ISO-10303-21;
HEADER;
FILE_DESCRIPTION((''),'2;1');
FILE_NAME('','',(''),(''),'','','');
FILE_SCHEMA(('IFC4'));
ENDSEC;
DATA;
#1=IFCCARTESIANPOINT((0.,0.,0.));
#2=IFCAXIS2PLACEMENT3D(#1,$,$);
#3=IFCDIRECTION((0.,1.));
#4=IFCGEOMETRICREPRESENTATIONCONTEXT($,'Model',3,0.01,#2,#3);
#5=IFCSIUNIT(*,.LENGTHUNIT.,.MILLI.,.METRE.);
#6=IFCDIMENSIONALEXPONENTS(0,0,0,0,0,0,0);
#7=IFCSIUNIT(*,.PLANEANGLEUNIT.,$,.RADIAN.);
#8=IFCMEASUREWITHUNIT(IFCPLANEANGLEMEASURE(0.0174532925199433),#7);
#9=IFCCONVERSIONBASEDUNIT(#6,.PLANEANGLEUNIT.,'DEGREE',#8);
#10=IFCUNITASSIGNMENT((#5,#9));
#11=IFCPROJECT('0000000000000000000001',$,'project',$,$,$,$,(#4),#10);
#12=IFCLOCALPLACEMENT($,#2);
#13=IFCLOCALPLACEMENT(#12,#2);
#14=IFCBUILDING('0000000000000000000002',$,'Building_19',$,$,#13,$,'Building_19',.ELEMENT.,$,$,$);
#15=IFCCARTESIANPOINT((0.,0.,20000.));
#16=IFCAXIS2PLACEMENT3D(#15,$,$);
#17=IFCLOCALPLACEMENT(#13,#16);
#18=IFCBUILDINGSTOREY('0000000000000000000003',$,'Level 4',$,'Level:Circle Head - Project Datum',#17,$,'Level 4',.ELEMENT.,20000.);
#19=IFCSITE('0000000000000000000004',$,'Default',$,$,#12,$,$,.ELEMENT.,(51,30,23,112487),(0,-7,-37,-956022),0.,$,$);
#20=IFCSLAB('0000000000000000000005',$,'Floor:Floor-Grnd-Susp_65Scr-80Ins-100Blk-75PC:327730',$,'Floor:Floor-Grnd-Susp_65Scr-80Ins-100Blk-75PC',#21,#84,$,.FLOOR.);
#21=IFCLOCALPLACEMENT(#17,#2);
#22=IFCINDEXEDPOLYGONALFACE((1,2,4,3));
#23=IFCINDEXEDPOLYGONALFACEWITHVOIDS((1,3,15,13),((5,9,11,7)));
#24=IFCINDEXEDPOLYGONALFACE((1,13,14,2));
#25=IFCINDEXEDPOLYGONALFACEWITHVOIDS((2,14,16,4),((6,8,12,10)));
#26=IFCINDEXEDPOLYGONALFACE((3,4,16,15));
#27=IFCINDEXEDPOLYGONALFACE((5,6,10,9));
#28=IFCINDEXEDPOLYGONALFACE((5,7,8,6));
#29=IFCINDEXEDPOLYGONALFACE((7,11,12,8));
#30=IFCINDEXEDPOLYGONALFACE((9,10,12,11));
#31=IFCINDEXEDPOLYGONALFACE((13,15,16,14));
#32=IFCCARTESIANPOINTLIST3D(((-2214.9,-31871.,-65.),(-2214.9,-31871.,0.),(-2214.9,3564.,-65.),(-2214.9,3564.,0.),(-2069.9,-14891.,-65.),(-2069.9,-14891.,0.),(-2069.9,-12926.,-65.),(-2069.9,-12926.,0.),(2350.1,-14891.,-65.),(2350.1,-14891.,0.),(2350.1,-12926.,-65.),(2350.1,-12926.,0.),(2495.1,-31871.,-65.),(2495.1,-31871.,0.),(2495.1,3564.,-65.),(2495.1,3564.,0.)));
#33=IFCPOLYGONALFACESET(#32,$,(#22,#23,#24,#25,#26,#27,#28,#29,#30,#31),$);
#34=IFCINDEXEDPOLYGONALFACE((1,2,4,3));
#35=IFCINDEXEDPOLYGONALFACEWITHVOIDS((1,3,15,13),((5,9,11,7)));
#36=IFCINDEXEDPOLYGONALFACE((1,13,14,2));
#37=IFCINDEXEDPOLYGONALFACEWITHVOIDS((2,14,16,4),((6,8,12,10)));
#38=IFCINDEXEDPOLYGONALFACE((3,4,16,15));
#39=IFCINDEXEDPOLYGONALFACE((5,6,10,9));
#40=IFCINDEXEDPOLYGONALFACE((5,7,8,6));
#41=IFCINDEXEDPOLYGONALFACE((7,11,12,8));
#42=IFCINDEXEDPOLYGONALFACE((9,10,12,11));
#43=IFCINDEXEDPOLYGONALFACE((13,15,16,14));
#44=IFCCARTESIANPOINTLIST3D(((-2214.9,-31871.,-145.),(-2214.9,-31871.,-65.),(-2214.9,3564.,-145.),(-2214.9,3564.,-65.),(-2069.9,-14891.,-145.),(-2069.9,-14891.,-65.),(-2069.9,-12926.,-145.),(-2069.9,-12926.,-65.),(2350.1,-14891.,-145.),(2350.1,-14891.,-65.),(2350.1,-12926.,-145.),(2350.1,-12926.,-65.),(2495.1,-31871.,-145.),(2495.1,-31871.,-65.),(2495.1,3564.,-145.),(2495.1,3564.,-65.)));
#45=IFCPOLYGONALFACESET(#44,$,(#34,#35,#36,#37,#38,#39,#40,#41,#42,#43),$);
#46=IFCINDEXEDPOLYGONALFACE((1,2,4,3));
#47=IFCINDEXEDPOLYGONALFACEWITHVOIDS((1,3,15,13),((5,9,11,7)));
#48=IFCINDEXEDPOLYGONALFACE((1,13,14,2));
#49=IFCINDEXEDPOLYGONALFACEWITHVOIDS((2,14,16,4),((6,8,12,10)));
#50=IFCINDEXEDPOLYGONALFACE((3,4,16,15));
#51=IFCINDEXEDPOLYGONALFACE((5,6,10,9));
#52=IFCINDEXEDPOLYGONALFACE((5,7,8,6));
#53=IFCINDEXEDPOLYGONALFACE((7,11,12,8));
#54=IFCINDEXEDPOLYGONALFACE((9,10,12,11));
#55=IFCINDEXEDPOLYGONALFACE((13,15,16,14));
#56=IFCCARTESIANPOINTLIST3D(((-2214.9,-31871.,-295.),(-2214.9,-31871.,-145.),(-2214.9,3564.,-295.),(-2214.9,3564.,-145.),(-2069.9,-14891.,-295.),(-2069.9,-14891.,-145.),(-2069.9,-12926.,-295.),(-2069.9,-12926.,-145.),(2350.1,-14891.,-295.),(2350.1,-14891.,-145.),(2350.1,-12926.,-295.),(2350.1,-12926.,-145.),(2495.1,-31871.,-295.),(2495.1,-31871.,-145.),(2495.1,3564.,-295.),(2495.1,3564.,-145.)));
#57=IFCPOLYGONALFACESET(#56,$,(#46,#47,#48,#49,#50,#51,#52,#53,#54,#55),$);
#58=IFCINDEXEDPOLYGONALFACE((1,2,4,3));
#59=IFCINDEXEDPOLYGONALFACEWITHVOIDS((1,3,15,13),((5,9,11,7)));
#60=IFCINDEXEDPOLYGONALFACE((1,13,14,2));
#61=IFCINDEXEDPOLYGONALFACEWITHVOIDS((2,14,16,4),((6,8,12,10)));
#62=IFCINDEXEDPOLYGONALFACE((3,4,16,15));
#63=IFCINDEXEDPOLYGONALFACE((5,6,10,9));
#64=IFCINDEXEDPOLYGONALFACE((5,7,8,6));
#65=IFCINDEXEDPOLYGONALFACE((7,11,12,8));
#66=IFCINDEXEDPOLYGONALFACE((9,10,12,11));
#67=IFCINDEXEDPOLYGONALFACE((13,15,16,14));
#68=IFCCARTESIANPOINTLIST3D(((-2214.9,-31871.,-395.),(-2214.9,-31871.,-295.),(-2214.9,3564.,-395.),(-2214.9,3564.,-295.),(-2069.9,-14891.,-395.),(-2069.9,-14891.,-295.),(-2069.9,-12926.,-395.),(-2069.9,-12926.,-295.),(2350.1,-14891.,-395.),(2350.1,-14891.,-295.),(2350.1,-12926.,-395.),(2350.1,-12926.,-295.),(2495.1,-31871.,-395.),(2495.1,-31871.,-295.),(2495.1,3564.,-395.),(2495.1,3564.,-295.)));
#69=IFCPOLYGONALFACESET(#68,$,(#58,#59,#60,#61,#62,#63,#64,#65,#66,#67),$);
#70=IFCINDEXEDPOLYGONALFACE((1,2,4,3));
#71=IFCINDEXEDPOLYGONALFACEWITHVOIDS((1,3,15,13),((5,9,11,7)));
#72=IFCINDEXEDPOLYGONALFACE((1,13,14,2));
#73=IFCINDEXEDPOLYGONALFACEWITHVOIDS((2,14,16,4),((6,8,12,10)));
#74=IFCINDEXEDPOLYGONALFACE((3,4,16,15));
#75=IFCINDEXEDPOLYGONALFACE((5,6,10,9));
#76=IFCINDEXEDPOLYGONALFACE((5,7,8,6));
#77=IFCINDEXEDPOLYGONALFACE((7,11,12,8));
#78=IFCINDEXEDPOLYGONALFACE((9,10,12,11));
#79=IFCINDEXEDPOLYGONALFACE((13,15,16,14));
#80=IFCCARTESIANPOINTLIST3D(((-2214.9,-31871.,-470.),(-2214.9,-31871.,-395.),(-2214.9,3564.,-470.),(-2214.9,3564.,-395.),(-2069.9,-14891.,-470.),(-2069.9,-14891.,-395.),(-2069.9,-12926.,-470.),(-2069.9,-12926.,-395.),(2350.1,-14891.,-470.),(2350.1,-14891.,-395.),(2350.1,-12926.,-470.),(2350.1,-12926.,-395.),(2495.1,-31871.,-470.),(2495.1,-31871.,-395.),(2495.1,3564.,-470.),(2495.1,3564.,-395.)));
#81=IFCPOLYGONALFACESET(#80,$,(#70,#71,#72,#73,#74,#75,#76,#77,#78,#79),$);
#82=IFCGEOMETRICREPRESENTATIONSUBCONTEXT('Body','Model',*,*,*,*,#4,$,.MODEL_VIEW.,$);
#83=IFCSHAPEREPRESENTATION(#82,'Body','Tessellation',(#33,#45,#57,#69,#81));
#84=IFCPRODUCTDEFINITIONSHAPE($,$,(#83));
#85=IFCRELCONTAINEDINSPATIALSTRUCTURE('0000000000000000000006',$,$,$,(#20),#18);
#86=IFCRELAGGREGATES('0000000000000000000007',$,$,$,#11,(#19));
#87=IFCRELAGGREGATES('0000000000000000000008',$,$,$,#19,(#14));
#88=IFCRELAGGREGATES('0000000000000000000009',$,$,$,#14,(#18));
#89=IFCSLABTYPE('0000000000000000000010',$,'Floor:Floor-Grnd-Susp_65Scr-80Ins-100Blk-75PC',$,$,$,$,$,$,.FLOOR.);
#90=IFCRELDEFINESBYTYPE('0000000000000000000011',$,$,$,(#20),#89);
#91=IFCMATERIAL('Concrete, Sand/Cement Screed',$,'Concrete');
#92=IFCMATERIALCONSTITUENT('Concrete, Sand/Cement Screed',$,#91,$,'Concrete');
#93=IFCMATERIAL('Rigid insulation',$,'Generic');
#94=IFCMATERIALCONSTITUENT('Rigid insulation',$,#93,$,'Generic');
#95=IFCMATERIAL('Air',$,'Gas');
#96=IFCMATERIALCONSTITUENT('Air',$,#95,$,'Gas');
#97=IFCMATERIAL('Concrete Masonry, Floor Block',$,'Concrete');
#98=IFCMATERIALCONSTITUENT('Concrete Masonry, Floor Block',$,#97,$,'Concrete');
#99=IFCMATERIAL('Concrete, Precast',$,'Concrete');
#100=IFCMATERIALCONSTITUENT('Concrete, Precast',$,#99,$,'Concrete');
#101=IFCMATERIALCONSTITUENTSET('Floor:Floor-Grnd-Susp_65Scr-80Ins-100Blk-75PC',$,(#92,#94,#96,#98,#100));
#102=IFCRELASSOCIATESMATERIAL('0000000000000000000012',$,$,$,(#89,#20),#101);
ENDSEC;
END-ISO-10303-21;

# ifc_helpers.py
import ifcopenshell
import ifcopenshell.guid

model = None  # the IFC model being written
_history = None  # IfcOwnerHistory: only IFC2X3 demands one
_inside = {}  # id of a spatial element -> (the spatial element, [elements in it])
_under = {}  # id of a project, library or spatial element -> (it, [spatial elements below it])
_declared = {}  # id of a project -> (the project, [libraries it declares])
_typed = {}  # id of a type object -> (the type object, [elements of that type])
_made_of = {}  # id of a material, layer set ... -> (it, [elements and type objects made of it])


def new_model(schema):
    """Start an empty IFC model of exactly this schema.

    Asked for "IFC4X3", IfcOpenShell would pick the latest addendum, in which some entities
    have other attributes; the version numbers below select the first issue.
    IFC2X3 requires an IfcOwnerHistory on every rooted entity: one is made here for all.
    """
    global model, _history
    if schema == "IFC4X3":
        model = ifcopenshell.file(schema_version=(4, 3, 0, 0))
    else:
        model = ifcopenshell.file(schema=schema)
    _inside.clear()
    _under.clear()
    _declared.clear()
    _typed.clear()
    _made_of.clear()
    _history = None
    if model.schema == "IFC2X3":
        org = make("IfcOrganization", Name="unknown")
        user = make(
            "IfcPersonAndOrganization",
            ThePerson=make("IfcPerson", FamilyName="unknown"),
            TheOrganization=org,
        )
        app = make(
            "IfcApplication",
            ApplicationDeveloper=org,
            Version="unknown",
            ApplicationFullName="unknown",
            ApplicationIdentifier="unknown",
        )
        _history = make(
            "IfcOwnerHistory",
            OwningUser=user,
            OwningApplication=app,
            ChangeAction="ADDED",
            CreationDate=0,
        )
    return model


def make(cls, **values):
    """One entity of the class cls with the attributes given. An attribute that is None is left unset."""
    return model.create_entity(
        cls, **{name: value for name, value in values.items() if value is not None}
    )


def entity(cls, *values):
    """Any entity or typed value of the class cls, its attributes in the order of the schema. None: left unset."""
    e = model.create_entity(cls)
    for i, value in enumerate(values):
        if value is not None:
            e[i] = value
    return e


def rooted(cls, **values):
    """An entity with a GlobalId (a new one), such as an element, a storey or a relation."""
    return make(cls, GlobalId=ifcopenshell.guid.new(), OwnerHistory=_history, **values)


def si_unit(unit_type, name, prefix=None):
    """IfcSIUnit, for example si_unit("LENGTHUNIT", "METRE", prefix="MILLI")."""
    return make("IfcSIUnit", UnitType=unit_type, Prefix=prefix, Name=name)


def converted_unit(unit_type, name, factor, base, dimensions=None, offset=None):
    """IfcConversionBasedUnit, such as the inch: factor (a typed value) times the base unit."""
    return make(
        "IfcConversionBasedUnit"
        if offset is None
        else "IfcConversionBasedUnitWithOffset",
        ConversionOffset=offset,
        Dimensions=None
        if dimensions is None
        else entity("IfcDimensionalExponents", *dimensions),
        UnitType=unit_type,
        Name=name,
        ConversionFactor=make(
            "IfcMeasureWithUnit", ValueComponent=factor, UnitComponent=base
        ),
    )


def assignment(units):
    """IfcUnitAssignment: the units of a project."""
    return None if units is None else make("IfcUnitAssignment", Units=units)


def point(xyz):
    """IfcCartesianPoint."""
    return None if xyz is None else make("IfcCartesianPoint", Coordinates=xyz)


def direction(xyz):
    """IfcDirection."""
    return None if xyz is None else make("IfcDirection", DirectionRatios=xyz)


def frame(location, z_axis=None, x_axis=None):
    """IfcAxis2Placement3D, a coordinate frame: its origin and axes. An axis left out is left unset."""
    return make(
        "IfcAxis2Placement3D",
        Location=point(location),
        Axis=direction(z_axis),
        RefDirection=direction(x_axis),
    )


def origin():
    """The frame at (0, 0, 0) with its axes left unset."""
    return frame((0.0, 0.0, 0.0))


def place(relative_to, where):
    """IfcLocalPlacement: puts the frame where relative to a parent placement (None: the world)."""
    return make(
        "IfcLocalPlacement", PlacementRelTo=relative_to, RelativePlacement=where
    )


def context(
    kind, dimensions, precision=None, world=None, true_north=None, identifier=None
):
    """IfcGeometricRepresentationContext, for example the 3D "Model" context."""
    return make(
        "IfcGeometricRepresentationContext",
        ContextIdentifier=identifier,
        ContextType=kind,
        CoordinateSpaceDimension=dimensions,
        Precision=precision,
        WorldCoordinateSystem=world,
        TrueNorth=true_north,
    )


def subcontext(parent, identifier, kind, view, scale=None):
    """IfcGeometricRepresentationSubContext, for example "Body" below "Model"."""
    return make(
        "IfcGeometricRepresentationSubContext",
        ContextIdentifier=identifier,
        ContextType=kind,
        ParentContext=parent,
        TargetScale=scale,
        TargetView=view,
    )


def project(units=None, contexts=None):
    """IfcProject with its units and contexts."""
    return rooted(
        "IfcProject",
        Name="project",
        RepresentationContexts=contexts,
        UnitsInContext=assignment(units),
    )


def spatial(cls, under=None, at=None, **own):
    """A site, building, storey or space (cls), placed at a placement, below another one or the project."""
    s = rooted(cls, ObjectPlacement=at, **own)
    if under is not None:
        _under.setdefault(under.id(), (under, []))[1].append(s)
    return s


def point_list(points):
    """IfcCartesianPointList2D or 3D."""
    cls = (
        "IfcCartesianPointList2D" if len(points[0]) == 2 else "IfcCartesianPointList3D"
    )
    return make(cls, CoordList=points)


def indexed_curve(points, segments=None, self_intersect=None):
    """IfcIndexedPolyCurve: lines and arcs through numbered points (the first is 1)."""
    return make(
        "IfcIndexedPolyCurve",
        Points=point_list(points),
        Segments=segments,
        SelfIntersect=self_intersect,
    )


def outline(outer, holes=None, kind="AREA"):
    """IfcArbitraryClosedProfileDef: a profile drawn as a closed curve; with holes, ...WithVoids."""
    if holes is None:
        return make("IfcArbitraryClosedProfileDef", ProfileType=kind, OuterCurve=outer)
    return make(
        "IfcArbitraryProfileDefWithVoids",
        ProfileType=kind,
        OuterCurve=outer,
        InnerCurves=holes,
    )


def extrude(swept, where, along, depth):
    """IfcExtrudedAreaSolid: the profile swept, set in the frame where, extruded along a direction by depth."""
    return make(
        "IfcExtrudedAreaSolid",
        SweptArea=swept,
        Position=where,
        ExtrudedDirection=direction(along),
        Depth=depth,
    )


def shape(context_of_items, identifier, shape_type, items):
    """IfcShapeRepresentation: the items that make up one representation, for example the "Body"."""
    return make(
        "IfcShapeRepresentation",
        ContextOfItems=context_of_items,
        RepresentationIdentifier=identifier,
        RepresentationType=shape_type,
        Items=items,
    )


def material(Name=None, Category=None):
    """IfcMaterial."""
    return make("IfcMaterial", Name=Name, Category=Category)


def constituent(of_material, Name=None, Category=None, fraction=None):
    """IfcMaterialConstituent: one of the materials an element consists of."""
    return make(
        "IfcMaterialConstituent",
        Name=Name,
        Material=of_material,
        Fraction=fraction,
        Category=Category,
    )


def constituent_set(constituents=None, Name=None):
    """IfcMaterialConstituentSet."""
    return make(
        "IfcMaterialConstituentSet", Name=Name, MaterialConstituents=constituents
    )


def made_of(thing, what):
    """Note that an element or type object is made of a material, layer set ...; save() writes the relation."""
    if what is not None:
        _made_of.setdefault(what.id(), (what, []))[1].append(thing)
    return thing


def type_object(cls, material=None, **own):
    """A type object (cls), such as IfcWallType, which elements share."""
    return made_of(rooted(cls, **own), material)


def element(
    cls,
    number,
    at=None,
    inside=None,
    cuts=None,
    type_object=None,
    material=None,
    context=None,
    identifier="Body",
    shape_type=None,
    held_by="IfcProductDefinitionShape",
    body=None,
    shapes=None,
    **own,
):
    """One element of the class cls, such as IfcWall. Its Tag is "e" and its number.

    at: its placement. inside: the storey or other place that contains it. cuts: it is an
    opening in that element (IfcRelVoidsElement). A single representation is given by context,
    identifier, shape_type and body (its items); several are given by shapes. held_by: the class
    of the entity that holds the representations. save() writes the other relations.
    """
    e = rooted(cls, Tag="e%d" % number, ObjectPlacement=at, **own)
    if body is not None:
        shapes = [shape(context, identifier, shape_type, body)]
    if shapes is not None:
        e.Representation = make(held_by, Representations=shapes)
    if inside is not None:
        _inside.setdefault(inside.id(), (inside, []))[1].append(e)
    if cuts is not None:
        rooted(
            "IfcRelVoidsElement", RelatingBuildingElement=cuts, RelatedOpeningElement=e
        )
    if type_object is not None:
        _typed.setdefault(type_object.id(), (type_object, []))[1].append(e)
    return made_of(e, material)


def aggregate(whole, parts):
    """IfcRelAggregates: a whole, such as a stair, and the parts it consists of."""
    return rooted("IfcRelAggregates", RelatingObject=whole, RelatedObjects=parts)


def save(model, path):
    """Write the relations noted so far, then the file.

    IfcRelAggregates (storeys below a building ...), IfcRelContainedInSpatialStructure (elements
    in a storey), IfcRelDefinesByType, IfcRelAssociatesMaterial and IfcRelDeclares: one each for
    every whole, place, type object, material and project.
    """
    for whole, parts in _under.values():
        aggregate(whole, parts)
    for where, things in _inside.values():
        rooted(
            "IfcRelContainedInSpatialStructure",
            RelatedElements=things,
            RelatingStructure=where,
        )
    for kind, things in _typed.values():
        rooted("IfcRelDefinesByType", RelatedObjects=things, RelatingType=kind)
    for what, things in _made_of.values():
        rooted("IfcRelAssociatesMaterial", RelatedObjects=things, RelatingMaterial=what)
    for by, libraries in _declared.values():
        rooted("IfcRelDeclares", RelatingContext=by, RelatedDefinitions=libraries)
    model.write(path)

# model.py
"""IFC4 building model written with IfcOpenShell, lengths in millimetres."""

from ifc_helpers import new_model, entity, si_unit, converted_unit, direction, frame, origin, place, context, subcontext, project, spatial, indexed_curve, outline, extrude, material, constituent, constituent_set, type_object, element, save


model = new_model("IFC4")

# Units and contexts
model_context = context("Model", 3, precision=0.01, world=origin(), true_north=direction((0.0, 1.0)))
body_context = subcontext(model_context, "Body", "Model", "MODEL_VIEW")
ifc_project = project(units=[si_unit("LENGTHUNIT", "METRE", prefix="MILLI"), converted_unit("PLANEANGLEUNIT", "DEGREE", entity("IfcPlaneAngleMeasure", 0.0174532925199433), si_unit("PLANEANGLEUNIT", "RADIAN"), dimensions=[0, 0, 0, 0, 0, 0, 0])], contexts=[model_context])

# Site, building, storey
site_placement = place(None, origin())
site = spatial("IfcSite", under=ifc_project, at=site_placement, Name="Default", CompositionType="ELEMENT", RefLatitude=(51, 30, 23, 112487), RefLongitude=(0, -7, -37, -956022), RefElevation=0.0)
building_placement = place(site_placement, origin())
building = spatial("IfcBuilding", under=site, at=building_placement, Name="Building_19", LongName="Building_19", CompositionType="ELEMENT")
storey_placement = place(building_placement, frame((0.0, 0.0, 20000.0)))
storey = spatial("IfcBuildingStorey", under=building, at=storey_placement, Name="Level 4", ObjectType="Level:Circle Head - Project Datum", LongName="Level 4", CompositionType="ELEMENT", Elevation=20000.0)

# Slab, opening
ifc_material_1 = material(Name="Concrete, Sand/Cement Screed", Category="Concrete")
ifc_constituent_1 = constituent(ifc_material_1, Name="Concrete, Sand/Cement Screed", Category="Concrete")
ifc_material_2 = material(Name="Rigid insulation", Category="Generic")
ifc_constituent_2 = constituent(ifc_material_2, Name="Rigid insulation", Category="Generic")
ifc_material_3 = material(Name="Air", Category="Gas")
ifc_constituent_3 = constituent(ifc_material_3, Name="Air", Category="Gas")
ifc_material_4 = material(Name="Concrete Masonry, Floor Block", Category="Concrete")
ifc_constituent_4 = constituent(ifc_material_4, Name="Concrete Masonry, Floor Block", Category="Concrete")
ifc_material_5 = material(Name="Concrete, Precast", Category="Concrete")
ifc_constituent_5 = constituent(ifc_material_5, Name="Concrete, Precast", Category="Concrete")
ifc_constituent_set = constituent_set(constituents=[ifc_constituent_1, ifc_constituent_2, ifc_constituent_3, ifc_constituent_4, ifc_constituent_5], Name="Floor:Floor-Grnd-Susp_65Scr-80Ins-100Blk-75PC")
slab_type = type_object("IfcSlabType", Name="Floor:Floor-Grnd-Susp_65Scr-80Ins-100Blk-75PC", PredefinedType="FLOOR", material=ifc_constituent_set)
slab_placement = place(storey_placement, origin())
slab = element("IfcSlab", 1, at=slab_placement, inside=storey, type_object=slab_type, material=ifc_constituent_set, Name="Floor:Floor-Grnd-Susp_65Scr-80Ins-100Blk-75PC:327730", ObjectType="Floor:Floor-Grnd-Susp_65Scr-80Ins-100Blk-75PC", PredefinedType="FLOOR", context=body_context, shape_type="SweptSolid", body=[
    extrude(outline(indexed_curve([(-2355.0, -17717.5), (2355.0, -17717.5), (2355.0, 17717.5), (-2355.0, 17717.5), (-2355.0, -17717.5)], self_intersect=False), holes=[indexed_curve([(-2210.0, 737.5), (2210.0, 737.5), (2210.0, -1227.5), (-2210.0, -1227.5), (-2210.0, 737.5)], self_intersect=False)]), frame((140.1, -14153.5, -65.0), z_axis=(0.0, 0.0, 1.0), x_axis=(-1.0, 0.0, 0.0)), (0.0, 0.0, 1.0), 65.0),
    extrude(outline(indexed_curve([(-2355.0, -17717.5), (2355.0, -17717.5), (2355.0, 17717.5), (-2355.0, 17717.5), (-2355.0, -17717.5)], self_intersect=False), holes=[indexed_curve([(-2210.0, 737.5), (2210.0, 737.5), (2210.0, -1227.5), (-2210.0, -1227.5), (-2210.0, 737.5)], self_intersect=False)]), frame((140.1, -14153.5, -145.0), z_axis=(0.0, 0.0, 1.0), x_axis=(-1.0, 0.0, 0.0)), (0.0, 0.0, 1.0), 80.0),
    extrude(outline(indexed_curve([(-2355.0, -17717.5), (2355.0, -17717.5), (2355.0, 17717.5), (-2355.0, 17717.5), (-2355.0, -17717.5)], self_intersect=False), holes=[indexed_curve([(-2210.0, 737.5), (2210.0, 737.5), (2210.0, -1227.5), (-2210.0, -1227.5), (-2210.0, 737.5)], self_intersect=False)]), frame((140.1, -14153.5, -295.0), z_axis=(0.0, 0.0, 1.0), x_axis=(-1.0, 0.0, 0.0)), (0.0, 0.0, 1.0), 150.0),
    extrude(outline(indexed_curve([(-2355.0, -17717.5), (2355.0, -17717.5), (2355.0, 17717.5), (-2355.0, 17717.5), (-2355.0, -17717.5)], self_intersect=False), holes=[indexed_curve([(-2210.0, 737.5), (2210.0, 737.5), (2210.0, -1227.5), (-2210.0, -1227.5), (-2210.0, 737.5)], self_intersect=False)]), frame((140.1, -14153.5, -395.0), z_axis=(0.0, 0.0, 1.0), x_axis=(-1.0, 0.0, 0.0)), (0.0, 0.0, 1.0), 100.0),
    extrude(outline(indexed_curve([(-2355.0, -17717.5), (2355.0, -17717.5), (2355.0, 17717.5), (-2355.0, 17717.5), (-2355.0, -17717.5)], self_intersect=False), holes=[indexed_curve([(-2210.0, 737.5), (2210.0, 737.5), (2210.0, -1227.5), (-2210.0, -1227.5), (-2210.0, 737.5)], self_intersect=False)]), frame((140.1, -14153.5, -470.0), z_axis=(0.0, 0.0, 1.0), x_axis=(-1.0, 0.0, 0.0)), (0.0, 0.0, 1.0), 75.0),
])
opening_placement = place(slab_placement, origin())
element("IfcOpeningElement", 2, at=opening_placement, cuts=slab, PredefinedType="OPENING", context=body_context, shape_type="SweptSolid", body=[
    extrude(outline(indexed_curve([(-982.5, -2210.0), (982.5, -2210.0), (982.5, 2210.0), (-982.5, 2210.0), (-982.5, -2210.0)], self_intersect=False)), frame((140.1, -13908.5, -470.0), z_axis=(0.0, 0.0, 1.0), x_axis=(0.0, 1.0, 0.0)), (0.0, 0.0, 1.0), 470.0),
])

save(model, "model.ifc")
